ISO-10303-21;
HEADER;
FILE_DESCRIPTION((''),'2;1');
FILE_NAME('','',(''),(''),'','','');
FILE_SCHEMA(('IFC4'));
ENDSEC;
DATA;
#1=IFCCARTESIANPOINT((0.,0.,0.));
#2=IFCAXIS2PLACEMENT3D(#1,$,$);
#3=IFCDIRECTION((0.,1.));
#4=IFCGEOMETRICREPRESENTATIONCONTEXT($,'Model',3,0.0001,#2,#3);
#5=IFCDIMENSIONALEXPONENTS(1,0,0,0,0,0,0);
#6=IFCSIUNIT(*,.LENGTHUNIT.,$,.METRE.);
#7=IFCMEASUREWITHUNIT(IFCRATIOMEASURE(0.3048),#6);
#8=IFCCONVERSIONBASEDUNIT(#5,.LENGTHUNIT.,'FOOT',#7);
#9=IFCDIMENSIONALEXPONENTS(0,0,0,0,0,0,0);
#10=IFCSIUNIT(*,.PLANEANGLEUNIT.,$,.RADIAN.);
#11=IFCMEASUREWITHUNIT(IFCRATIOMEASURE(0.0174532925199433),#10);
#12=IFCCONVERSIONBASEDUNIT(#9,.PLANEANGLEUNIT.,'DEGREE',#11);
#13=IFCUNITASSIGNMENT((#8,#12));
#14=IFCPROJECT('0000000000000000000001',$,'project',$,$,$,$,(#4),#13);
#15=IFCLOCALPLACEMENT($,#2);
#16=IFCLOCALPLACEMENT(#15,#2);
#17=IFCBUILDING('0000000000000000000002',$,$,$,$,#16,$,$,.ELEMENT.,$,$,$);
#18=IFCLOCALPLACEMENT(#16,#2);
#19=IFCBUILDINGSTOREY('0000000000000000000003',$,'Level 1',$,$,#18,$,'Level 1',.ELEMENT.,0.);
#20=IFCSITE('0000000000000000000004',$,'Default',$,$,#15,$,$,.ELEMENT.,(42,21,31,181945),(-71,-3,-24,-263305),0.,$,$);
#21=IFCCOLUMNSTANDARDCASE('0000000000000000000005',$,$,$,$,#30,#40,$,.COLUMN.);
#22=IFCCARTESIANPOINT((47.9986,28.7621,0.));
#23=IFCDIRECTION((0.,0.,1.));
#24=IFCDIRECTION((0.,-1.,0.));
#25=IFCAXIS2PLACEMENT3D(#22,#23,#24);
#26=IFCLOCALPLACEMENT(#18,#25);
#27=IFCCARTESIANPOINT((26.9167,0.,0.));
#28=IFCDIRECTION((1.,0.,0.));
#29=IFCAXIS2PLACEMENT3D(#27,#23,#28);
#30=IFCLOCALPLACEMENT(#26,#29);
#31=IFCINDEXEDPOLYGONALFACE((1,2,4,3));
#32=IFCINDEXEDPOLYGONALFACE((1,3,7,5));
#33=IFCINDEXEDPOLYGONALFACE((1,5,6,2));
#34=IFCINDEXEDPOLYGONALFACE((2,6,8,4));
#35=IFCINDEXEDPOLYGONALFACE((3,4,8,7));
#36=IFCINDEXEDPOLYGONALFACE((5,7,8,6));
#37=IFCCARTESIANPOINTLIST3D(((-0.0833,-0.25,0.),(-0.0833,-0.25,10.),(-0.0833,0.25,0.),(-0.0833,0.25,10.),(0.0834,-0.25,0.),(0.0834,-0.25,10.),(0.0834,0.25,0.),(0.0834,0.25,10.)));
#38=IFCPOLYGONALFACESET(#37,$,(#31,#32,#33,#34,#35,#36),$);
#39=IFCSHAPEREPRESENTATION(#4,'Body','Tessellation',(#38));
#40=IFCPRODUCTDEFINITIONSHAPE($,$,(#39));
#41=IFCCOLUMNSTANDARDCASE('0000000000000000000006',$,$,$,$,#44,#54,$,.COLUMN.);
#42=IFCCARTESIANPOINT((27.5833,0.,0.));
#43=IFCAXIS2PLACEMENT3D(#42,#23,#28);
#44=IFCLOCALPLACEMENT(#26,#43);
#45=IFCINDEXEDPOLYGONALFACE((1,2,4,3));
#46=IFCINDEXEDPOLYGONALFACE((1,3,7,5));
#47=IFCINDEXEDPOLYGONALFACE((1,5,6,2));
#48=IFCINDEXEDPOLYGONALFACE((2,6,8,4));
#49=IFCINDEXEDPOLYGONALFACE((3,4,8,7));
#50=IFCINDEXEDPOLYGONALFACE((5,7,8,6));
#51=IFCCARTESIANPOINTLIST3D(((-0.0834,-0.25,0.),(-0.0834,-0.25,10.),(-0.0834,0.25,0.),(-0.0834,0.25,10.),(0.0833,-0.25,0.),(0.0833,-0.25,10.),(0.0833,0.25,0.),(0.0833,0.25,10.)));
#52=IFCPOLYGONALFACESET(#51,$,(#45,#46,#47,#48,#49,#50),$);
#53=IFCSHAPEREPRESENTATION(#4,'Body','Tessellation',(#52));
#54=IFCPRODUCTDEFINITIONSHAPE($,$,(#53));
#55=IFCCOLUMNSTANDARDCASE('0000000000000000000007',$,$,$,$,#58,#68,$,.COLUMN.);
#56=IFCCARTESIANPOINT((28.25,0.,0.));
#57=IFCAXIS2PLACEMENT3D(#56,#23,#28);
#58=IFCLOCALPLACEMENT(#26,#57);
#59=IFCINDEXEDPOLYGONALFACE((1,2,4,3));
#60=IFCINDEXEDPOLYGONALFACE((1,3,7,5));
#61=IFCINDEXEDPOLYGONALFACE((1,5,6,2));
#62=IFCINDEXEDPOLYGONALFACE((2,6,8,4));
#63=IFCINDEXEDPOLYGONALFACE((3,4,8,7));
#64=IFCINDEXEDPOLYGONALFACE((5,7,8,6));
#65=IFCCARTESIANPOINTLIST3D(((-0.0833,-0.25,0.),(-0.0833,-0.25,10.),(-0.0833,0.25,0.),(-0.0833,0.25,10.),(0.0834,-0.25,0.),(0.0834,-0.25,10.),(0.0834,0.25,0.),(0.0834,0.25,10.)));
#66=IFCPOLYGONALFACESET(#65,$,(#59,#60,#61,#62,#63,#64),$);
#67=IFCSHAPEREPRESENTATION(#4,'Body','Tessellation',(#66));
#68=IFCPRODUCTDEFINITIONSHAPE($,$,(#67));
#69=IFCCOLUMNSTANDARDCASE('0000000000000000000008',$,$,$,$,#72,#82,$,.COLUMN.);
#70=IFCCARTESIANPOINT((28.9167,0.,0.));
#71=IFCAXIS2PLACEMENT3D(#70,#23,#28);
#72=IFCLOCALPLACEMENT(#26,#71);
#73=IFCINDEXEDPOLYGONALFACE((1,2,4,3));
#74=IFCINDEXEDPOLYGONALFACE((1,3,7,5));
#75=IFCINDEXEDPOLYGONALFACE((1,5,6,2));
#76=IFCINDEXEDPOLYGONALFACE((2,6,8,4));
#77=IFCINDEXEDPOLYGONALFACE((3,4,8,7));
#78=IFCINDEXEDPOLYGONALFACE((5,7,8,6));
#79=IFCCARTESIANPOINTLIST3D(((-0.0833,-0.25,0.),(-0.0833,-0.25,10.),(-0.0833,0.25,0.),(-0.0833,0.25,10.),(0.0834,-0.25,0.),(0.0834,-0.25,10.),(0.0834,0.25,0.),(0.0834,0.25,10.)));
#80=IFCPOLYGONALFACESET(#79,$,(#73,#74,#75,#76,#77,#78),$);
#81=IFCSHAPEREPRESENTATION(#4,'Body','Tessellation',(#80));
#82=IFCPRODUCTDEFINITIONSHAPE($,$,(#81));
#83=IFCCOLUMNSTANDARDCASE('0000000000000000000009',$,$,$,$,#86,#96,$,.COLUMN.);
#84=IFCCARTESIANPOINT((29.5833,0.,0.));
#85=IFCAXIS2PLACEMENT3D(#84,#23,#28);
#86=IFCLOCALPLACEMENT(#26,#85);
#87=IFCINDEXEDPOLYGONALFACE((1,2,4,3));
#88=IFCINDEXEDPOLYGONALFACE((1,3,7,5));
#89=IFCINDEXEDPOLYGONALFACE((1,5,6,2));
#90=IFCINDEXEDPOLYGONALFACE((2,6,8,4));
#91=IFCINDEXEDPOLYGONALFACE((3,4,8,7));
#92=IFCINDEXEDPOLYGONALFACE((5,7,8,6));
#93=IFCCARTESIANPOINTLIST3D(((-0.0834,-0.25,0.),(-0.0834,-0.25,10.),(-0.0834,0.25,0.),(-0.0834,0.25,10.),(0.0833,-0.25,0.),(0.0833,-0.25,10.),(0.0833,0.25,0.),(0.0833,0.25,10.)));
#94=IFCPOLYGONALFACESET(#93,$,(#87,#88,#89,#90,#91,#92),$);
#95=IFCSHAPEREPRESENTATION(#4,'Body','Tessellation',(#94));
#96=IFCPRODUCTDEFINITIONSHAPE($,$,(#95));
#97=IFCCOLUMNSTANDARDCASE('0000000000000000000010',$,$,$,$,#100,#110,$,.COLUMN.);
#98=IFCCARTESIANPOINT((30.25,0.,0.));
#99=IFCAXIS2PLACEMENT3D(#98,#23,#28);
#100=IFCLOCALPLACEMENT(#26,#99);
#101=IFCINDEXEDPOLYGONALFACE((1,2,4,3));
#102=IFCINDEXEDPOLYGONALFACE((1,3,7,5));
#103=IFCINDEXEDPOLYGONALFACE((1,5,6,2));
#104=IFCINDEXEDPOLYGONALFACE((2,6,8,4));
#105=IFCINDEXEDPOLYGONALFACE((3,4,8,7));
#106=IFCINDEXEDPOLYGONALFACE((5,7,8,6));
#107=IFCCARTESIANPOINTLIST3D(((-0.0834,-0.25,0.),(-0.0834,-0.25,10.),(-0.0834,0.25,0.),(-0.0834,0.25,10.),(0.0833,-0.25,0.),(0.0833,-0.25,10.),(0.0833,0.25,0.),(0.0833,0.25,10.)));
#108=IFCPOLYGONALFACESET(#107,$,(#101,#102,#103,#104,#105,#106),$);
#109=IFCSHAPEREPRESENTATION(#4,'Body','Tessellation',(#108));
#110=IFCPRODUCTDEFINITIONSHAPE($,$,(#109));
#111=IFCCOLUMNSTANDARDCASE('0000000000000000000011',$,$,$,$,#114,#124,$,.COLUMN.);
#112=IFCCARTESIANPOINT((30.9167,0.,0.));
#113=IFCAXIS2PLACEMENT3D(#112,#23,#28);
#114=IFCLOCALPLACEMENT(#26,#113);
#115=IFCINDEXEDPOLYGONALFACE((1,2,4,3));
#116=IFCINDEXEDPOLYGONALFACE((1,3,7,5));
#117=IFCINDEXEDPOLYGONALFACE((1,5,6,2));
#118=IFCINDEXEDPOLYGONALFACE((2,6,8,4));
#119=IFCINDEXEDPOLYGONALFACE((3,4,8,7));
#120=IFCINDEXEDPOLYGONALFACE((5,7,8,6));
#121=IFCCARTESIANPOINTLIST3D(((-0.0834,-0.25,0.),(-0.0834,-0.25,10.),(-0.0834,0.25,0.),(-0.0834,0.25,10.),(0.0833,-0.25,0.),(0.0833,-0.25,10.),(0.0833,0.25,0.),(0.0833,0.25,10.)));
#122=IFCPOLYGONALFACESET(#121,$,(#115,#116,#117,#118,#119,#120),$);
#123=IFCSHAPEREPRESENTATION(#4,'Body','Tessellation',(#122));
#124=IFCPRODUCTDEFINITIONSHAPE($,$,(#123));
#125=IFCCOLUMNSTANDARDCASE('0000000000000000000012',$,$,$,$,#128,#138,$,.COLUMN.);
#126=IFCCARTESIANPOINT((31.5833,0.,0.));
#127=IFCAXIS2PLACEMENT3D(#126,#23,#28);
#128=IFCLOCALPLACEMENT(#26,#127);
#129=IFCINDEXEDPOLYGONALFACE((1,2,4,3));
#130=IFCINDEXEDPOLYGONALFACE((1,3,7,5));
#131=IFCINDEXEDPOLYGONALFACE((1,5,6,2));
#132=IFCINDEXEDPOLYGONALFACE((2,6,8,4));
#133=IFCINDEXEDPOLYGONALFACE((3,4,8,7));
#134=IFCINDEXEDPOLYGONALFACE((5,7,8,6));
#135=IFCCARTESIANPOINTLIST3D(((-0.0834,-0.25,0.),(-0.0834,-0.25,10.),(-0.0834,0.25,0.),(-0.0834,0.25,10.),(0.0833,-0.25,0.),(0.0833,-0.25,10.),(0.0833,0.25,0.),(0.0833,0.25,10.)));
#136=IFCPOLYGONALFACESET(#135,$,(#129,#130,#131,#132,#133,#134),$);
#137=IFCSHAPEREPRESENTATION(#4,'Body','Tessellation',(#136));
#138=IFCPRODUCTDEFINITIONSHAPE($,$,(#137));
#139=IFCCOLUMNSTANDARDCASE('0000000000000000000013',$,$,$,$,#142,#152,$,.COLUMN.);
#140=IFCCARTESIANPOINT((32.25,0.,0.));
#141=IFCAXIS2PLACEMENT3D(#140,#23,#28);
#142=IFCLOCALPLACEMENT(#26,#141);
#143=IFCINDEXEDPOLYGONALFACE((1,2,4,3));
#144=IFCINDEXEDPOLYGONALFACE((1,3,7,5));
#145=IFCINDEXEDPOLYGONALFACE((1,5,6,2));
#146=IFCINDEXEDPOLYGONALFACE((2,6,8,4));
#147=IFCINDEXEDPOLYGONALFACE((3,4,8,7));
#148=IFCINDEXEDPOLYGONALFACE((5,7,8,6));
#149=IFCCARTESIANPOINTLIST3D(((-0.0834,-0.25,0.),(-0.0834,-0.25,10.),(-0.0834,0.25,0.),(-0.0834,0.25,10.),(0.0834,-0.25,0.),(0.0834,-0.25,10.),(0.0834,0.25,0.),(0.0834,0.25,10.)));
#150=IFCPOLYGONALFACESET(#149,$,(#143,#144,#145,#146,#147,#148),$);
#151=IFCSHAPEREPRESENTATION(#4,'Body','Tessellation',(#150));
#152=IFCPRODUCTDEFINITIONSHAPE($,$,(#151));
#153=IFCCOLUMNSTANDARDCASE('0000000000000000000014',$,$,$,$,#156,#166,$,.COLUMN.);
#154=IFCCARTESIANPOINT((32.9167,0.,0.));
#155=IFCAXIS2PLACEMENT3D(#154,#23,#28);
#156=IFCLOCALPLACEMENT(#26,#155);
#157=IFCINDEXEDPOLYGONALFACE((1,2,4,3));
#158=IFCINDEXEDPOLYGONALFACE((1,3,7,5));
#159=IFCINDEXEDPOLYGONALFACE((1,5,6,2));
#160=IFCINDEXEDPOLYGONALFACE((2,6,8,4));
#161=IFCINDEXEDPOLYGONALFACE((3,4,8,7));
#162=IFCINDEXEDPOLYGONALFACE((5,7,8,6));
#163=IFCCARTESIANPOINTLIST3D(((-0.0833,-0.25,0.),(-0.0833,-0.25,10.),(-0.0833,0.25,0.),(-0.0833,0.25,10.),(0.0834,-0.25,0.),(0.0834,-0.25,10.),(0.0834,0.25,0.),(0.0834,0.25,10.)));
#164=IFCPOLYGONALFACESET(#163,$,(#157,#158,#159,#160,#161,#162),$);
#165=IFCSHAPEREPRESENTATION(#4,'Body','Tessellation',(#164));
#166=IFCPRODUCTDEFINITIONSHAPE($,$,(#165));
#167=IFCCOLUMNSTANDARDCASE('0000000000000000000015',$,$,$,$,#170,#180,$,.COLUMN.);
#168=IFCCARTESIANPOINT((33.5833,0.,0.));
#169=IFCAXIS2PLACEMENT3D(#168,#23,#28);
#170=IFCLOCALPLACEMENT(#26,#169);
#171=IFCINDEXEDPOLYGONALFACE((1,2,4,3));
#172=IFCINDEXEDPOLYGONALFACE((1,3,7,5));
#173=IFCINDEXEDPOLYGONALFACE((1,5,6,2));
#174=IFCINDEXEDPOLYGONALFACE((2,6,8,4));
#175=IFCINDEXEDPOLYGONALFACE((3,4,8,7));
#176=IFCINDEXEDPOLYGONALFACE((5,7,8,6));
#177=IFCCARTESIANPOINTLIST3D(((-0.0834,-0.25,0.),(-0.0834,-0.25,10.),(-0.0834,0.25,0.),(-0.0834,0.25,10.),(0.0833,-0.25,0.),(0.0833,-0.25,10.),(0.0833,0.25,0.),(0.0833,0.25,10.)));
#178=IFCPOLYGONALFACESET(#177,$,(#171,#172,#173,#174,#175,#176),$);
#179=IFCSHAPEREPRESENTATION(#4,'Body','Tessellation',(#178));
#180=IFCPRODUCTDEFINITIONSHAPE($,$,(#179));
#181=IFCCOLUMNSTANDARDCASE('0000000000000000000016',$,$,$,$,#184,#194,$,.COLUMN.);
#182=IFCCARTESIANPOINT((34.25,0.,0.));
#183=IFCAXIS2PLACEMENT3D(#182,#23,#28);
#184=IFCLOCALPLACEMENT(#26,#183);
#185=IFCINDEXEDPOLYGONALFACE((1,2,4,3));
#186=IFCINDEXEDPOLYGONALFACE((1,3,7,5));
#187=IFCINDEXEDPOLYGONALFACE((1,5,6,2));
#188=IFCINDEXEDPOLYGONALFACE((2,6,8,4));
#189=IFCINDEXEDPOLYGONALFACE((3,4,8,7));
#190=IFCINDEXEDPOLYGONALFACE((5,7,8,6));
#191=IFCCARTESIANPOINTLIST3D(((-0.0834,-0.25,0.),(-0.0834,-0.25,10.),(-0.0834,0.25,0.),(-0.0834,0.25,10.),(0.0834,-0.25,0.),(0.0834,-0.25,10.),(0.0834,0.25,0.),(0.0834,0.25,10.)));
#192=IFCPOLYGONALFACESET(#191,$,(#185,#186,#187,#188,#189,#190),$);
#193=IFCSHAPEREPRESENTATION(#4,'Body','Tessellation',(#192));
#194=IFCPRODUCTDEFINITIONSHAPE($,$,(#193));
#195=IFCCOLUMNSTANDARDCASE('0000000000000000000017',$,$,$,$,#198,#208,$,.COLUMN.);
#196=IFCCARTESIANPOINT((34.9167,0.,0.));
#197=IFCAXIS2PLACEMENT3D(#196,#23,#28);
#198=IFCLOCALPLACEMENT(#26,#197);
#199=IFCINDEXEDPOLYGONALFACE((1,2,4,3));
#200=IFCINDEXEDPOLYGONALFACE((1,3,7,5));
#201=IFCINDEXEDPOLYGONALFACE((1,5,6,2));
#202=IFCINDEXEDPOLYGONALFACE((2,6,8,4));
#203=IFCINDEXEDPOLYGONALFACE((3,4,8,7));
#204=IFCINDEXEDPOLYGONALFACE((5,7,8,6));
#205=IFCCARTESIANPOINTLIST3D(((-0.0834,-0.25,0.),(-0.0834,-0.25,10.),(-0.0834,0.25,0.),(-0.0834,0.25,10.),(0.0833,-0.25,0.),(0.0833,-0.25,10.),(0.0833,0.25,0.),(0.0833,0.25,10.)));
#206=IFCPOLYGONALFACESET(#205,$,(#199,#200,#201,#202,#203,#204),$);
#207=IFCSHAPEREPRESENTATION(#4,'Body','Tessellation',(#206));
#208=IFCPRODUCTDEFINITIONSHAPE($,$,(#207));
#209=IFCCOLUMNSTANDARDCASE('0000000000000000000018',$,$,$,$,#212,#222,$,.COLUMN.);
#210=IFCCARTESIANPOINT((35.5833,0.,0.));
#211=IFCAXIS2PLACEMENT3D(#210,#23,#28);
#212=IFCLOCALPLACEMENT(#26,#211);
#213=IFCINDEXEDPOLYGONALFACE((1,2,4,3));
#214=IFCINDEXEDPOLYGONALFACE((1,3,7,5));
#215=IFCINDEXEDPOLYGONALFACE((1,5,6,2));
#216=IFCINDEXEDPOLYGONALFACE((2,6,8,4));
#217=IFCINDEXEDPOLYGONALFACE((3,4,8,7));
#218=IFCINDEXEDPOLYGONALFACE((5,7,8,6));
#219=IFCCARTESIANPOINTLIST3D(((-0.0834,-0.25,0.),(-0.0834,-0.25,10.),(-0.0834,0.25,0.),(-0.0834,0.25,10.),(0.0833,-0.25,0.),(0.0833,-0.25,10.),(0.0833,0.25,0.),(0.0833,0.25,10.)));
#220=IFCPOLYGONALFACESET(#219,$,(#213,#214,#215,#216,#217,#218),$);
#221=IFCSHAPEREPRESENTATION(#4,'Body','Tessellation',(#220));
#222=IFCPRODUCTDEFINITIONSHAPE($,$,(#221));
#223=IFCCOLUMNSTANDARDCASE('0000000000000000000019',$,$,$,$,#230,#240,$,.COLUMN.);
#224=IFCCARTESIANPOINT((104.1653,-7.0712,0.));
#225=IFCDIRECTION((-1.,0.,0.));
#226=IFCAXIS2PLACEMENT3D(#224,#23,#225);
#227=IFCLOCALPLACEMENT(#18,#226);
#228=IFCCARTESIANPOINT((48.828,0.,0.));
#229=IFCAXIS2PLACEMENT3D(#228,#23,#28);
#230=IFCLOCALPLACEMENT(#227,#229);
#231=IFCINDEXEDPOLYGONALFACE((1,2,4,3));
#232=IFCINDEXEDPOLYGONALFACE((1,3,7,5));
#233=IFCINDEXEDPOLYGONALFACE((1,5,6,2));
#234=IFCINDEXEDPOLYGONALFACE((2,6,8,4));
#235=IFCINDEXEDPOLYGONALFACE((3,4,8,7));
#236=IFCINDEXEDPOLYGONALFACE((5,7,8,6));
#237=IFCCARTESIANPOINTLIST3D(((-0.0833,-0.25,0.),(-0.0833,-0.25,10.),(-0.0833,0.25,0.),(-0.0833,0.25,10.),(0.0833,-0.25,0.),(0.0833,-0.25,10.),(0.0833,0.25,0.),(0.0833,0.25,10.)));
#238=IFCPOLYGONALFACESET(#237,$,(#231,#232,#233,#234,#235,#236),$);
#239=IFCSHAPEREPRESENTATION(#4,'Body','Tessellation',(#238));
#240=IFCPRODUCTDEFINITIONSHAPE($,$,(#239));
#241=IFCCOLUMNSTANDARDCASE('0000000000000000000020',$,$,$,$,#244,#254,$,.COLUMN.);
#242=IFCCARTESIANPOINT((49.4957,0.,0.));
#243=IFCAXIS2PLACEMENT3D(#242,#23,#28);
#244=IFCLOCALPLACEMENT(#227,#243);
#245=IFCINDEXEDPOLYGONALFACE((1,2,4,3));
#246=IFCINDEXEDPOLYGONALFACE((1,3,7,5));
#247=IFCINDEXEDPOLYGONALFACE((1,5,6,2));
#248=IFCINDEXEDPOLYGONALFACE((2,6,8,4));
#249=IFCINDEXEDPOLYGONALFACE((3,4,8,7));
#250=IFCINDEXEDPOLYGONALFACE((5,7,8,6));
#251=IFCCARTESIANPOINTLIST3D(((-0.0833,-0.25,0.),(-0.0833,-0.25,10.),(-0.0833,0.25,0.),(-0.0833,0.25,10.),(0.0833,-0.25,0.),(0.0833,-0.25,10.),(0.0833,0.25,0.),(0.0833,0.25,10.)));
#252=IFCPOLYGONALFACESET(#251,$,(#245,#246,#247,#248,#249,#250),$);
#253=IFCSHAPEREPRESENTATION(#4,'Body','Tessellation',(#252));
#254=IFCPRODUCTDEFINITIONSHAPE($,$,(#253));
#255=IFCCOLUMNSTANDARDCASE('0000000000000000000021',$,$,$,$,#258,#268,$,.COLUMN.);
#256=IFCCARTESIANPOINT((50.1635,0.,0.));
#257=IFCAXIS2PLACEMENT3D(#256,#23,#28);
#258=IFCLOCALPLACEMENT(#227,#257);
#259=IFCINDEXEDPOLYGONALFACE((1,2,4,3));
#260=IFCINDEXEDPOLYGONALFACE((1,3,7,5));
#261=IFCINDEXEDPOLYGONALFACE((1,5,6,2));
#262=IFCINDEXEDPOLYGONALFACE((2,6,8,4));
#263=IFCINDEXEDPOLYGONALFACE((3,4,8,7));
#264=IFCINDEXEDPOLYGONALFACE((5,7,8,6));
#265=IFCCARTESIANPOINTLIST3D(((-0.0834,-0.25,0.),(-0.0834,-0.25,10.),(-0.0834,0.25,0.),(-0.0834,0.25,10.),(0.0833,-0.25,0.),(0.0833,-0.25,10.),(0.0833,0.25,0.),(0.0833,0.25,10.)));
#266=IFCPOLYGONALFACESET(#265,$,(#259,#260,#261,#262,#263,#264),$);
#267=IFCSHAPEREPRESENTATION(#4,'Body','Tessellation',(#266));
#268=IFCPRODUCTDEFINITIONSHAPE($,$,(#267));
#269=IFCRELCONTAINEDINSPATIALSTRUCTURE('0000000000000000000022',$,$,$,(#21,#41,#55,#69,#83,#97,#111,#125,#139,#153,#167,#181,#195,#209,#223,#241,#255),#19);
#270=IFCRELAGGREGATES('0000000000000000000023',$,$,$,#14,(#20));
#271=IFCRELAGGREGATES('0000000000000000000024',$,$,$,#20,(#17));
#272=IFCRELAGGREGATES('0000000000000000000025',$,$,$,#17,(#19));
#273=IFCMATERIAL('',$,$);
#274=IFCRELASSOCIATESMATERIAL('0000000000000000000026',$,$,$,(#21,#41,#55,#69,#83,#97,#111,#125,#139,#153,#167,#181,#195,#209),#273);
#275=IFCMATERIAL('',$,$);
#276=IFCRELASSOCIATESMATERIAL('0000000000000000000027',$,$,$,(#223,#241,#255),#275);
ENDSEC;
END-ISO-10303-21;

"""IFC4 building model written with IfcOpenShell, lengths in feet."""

from ifc_helpers import new_model, entity, si_unit, converted_unit, direction, frame, origin, place, context, project, spatial, rectangle, extrude, material, element, save


model = new_model("IFC4")

# Units and contexts
model_context = context("Model", 3, precision=0.0001, world=origin(), true_north=direction((0.0, 1.0)))
ifc_project = project(units=[converted_unit("LENGTHUNIT", "FOOT", entity("IfcRatioMeasure", 0.3048), si_unit("LENGTHUNIT", "METRE"), dimensions=[1, 0, 0, 0, 0, 0, 0]), converted_unit("PLANEANGLEUNIT", "DEGREE", entity("IfcRatioMeasure", 0.0174532925199433), si_unit("PLANEANGLEUNIT", "RADIAN"), dimensions=[0, 0, 0, 0, 0, 0, 0])], contexts=[model_context])

# Site, building, storey
site_placement = place(None, origin())
site = spatial("IfcSite", under=ifc_project, at=site_placement, Name="Default", CompositionType="ELEMENT", RefLatitude=(42, 21, 31, 181945), RefLongitude=(-71, -3, -24, -263305), RefElevation=0.0)
building_placement = place(site_placement, origin())
building = spatial("IfcBuilding", under=site, at=building_placement, CompositionType="ELEMENT")
storey_placement = place(building_placement, origin())
storey = spatial("IfcBuildingStorey", under=building, at=storey_placement, Name="Level 1", LongName="Level 1", CompositionType="ELEMENT", Elevation=0.0)

# Columns
ifc_material_1 = material(Name="")
placement_1 = place(storey_placement, frame((47.9986, 28.7621, 0.0), z_axis=(0.0, 0.0, 1.0), x_axis=(0.0, -1.0, 0.0)))
for number, where, z_axis, x_axis in (
    (1, (26.9167, 0.0, 0.0), (0.0, 0.0, 1.0), (1.0, 0.0, 0.0)),
    (2, (27.5833, 0.0, 0.0), (0.0, 0.0, 1.0), (1.0, 0.0, 0.0)),
    (3, (28.25, 0.0, 0.0), (0.0, 0.0, 1.0), (1.0, 0.0, 0.0)),
    (4, (28.9167, 0.0, 0.0), (0.0, 0.0, 1.0), (1.0, 0.0, 0.0)),
    (5, (29.5833, 0.0, 0.0), (0.0, 0.0, 1.0), (1.0, 0.0, 0.0)),
    (6, (30.25, 0.0, 0.0), (0.0, 0.0, 1.0), (1.0, 0.0, 0.0)),
    (7, (30.9167, 0.0, 0.0), (0.0, 0.0, 1.0), (1.0, 0.0, 0.0)),
    (8, (31.5833, 0.0, 0.0), (0.0, 0.0, 1.0), (1.0, 0.0, 0.0)),
    (9, (32.25, 0.0, 0.0), (0.0, 0.0, 1.0), (1.0, 0.0, 0.0)),
    (10, (32.9167, 0.0, 0.0), (0.0, 0.0, 1.0), (1.0, 0.0, 0.0)),
    (11, (33.5833, 0.0, 0.0), (0.0, 0.0, 1.0), (1.0, 0.0, 0.0)),
    (12, (34.25, 0.0, 0.0), (0.0, 0.0, 1.0), (1.0, 0.0, 0.0)),
    (13, (34.9167, 0.0, 0.0), (0.0, 0.0, 1.0), (1.0, 0.0, 0.0)),
    (14, (35.5833, 0.0, 0.0), (0.0, 0.0, 1.0), (1.0, 0.0, 0.0)),
):
    element("IfcColumnStandardCase", number, at=place(placement_1, frame(where, z_axis=z_axis, x_axis=x_axis)), inside=storey, material=ifc_material_1, PredefinedType="COLUMN", context=model_context, shape_type="SweptSolid", body=[
        extrude(rectangle(XDim=0.1667, YDim=0.5), origin(), (0.0, 0.0, 1.0), 10.0),
    ])
ifc_material_2 = material(Name="")
placement_2 = place(storey_placement, frame((104.1653, -7.0712, 0.0), z_axis=(0.0, 0.0, 1.0), x_axis=(-1.0, 0.0, 0.0)))
for number, where, z_axis, x_axis in (
    (15, (48.828, 0.0, 0.0), (0.0, 0.0, 1.0), (1.0, 0.0, 0.0)),
    (16, (49.4957, 0.0, 0.0), (0.0, 0.0, 1.0), (1.0, 0.0, 0.0)),
    (17, (50.1635, 0.0, 0.0), (0.0, 0.0, 1.0), (1.0, 0.0, 0.0)),
):
    element("IfcColumnStandardCase", number, at=place(placement_2, frame(where, z_axis=z_axis, x_axis=x_axis)), inside=storey, material=ifc_material_2, PredefinedType="COLUMN", context=model_context, shape_type="SweptSolid", body=[
        extrude(rectangle(XDim=0.1667, YDim=0.5), origin(), (0.0, 0.0, 1.0), 10.0),
    ])

save(model, "model.ifc")
